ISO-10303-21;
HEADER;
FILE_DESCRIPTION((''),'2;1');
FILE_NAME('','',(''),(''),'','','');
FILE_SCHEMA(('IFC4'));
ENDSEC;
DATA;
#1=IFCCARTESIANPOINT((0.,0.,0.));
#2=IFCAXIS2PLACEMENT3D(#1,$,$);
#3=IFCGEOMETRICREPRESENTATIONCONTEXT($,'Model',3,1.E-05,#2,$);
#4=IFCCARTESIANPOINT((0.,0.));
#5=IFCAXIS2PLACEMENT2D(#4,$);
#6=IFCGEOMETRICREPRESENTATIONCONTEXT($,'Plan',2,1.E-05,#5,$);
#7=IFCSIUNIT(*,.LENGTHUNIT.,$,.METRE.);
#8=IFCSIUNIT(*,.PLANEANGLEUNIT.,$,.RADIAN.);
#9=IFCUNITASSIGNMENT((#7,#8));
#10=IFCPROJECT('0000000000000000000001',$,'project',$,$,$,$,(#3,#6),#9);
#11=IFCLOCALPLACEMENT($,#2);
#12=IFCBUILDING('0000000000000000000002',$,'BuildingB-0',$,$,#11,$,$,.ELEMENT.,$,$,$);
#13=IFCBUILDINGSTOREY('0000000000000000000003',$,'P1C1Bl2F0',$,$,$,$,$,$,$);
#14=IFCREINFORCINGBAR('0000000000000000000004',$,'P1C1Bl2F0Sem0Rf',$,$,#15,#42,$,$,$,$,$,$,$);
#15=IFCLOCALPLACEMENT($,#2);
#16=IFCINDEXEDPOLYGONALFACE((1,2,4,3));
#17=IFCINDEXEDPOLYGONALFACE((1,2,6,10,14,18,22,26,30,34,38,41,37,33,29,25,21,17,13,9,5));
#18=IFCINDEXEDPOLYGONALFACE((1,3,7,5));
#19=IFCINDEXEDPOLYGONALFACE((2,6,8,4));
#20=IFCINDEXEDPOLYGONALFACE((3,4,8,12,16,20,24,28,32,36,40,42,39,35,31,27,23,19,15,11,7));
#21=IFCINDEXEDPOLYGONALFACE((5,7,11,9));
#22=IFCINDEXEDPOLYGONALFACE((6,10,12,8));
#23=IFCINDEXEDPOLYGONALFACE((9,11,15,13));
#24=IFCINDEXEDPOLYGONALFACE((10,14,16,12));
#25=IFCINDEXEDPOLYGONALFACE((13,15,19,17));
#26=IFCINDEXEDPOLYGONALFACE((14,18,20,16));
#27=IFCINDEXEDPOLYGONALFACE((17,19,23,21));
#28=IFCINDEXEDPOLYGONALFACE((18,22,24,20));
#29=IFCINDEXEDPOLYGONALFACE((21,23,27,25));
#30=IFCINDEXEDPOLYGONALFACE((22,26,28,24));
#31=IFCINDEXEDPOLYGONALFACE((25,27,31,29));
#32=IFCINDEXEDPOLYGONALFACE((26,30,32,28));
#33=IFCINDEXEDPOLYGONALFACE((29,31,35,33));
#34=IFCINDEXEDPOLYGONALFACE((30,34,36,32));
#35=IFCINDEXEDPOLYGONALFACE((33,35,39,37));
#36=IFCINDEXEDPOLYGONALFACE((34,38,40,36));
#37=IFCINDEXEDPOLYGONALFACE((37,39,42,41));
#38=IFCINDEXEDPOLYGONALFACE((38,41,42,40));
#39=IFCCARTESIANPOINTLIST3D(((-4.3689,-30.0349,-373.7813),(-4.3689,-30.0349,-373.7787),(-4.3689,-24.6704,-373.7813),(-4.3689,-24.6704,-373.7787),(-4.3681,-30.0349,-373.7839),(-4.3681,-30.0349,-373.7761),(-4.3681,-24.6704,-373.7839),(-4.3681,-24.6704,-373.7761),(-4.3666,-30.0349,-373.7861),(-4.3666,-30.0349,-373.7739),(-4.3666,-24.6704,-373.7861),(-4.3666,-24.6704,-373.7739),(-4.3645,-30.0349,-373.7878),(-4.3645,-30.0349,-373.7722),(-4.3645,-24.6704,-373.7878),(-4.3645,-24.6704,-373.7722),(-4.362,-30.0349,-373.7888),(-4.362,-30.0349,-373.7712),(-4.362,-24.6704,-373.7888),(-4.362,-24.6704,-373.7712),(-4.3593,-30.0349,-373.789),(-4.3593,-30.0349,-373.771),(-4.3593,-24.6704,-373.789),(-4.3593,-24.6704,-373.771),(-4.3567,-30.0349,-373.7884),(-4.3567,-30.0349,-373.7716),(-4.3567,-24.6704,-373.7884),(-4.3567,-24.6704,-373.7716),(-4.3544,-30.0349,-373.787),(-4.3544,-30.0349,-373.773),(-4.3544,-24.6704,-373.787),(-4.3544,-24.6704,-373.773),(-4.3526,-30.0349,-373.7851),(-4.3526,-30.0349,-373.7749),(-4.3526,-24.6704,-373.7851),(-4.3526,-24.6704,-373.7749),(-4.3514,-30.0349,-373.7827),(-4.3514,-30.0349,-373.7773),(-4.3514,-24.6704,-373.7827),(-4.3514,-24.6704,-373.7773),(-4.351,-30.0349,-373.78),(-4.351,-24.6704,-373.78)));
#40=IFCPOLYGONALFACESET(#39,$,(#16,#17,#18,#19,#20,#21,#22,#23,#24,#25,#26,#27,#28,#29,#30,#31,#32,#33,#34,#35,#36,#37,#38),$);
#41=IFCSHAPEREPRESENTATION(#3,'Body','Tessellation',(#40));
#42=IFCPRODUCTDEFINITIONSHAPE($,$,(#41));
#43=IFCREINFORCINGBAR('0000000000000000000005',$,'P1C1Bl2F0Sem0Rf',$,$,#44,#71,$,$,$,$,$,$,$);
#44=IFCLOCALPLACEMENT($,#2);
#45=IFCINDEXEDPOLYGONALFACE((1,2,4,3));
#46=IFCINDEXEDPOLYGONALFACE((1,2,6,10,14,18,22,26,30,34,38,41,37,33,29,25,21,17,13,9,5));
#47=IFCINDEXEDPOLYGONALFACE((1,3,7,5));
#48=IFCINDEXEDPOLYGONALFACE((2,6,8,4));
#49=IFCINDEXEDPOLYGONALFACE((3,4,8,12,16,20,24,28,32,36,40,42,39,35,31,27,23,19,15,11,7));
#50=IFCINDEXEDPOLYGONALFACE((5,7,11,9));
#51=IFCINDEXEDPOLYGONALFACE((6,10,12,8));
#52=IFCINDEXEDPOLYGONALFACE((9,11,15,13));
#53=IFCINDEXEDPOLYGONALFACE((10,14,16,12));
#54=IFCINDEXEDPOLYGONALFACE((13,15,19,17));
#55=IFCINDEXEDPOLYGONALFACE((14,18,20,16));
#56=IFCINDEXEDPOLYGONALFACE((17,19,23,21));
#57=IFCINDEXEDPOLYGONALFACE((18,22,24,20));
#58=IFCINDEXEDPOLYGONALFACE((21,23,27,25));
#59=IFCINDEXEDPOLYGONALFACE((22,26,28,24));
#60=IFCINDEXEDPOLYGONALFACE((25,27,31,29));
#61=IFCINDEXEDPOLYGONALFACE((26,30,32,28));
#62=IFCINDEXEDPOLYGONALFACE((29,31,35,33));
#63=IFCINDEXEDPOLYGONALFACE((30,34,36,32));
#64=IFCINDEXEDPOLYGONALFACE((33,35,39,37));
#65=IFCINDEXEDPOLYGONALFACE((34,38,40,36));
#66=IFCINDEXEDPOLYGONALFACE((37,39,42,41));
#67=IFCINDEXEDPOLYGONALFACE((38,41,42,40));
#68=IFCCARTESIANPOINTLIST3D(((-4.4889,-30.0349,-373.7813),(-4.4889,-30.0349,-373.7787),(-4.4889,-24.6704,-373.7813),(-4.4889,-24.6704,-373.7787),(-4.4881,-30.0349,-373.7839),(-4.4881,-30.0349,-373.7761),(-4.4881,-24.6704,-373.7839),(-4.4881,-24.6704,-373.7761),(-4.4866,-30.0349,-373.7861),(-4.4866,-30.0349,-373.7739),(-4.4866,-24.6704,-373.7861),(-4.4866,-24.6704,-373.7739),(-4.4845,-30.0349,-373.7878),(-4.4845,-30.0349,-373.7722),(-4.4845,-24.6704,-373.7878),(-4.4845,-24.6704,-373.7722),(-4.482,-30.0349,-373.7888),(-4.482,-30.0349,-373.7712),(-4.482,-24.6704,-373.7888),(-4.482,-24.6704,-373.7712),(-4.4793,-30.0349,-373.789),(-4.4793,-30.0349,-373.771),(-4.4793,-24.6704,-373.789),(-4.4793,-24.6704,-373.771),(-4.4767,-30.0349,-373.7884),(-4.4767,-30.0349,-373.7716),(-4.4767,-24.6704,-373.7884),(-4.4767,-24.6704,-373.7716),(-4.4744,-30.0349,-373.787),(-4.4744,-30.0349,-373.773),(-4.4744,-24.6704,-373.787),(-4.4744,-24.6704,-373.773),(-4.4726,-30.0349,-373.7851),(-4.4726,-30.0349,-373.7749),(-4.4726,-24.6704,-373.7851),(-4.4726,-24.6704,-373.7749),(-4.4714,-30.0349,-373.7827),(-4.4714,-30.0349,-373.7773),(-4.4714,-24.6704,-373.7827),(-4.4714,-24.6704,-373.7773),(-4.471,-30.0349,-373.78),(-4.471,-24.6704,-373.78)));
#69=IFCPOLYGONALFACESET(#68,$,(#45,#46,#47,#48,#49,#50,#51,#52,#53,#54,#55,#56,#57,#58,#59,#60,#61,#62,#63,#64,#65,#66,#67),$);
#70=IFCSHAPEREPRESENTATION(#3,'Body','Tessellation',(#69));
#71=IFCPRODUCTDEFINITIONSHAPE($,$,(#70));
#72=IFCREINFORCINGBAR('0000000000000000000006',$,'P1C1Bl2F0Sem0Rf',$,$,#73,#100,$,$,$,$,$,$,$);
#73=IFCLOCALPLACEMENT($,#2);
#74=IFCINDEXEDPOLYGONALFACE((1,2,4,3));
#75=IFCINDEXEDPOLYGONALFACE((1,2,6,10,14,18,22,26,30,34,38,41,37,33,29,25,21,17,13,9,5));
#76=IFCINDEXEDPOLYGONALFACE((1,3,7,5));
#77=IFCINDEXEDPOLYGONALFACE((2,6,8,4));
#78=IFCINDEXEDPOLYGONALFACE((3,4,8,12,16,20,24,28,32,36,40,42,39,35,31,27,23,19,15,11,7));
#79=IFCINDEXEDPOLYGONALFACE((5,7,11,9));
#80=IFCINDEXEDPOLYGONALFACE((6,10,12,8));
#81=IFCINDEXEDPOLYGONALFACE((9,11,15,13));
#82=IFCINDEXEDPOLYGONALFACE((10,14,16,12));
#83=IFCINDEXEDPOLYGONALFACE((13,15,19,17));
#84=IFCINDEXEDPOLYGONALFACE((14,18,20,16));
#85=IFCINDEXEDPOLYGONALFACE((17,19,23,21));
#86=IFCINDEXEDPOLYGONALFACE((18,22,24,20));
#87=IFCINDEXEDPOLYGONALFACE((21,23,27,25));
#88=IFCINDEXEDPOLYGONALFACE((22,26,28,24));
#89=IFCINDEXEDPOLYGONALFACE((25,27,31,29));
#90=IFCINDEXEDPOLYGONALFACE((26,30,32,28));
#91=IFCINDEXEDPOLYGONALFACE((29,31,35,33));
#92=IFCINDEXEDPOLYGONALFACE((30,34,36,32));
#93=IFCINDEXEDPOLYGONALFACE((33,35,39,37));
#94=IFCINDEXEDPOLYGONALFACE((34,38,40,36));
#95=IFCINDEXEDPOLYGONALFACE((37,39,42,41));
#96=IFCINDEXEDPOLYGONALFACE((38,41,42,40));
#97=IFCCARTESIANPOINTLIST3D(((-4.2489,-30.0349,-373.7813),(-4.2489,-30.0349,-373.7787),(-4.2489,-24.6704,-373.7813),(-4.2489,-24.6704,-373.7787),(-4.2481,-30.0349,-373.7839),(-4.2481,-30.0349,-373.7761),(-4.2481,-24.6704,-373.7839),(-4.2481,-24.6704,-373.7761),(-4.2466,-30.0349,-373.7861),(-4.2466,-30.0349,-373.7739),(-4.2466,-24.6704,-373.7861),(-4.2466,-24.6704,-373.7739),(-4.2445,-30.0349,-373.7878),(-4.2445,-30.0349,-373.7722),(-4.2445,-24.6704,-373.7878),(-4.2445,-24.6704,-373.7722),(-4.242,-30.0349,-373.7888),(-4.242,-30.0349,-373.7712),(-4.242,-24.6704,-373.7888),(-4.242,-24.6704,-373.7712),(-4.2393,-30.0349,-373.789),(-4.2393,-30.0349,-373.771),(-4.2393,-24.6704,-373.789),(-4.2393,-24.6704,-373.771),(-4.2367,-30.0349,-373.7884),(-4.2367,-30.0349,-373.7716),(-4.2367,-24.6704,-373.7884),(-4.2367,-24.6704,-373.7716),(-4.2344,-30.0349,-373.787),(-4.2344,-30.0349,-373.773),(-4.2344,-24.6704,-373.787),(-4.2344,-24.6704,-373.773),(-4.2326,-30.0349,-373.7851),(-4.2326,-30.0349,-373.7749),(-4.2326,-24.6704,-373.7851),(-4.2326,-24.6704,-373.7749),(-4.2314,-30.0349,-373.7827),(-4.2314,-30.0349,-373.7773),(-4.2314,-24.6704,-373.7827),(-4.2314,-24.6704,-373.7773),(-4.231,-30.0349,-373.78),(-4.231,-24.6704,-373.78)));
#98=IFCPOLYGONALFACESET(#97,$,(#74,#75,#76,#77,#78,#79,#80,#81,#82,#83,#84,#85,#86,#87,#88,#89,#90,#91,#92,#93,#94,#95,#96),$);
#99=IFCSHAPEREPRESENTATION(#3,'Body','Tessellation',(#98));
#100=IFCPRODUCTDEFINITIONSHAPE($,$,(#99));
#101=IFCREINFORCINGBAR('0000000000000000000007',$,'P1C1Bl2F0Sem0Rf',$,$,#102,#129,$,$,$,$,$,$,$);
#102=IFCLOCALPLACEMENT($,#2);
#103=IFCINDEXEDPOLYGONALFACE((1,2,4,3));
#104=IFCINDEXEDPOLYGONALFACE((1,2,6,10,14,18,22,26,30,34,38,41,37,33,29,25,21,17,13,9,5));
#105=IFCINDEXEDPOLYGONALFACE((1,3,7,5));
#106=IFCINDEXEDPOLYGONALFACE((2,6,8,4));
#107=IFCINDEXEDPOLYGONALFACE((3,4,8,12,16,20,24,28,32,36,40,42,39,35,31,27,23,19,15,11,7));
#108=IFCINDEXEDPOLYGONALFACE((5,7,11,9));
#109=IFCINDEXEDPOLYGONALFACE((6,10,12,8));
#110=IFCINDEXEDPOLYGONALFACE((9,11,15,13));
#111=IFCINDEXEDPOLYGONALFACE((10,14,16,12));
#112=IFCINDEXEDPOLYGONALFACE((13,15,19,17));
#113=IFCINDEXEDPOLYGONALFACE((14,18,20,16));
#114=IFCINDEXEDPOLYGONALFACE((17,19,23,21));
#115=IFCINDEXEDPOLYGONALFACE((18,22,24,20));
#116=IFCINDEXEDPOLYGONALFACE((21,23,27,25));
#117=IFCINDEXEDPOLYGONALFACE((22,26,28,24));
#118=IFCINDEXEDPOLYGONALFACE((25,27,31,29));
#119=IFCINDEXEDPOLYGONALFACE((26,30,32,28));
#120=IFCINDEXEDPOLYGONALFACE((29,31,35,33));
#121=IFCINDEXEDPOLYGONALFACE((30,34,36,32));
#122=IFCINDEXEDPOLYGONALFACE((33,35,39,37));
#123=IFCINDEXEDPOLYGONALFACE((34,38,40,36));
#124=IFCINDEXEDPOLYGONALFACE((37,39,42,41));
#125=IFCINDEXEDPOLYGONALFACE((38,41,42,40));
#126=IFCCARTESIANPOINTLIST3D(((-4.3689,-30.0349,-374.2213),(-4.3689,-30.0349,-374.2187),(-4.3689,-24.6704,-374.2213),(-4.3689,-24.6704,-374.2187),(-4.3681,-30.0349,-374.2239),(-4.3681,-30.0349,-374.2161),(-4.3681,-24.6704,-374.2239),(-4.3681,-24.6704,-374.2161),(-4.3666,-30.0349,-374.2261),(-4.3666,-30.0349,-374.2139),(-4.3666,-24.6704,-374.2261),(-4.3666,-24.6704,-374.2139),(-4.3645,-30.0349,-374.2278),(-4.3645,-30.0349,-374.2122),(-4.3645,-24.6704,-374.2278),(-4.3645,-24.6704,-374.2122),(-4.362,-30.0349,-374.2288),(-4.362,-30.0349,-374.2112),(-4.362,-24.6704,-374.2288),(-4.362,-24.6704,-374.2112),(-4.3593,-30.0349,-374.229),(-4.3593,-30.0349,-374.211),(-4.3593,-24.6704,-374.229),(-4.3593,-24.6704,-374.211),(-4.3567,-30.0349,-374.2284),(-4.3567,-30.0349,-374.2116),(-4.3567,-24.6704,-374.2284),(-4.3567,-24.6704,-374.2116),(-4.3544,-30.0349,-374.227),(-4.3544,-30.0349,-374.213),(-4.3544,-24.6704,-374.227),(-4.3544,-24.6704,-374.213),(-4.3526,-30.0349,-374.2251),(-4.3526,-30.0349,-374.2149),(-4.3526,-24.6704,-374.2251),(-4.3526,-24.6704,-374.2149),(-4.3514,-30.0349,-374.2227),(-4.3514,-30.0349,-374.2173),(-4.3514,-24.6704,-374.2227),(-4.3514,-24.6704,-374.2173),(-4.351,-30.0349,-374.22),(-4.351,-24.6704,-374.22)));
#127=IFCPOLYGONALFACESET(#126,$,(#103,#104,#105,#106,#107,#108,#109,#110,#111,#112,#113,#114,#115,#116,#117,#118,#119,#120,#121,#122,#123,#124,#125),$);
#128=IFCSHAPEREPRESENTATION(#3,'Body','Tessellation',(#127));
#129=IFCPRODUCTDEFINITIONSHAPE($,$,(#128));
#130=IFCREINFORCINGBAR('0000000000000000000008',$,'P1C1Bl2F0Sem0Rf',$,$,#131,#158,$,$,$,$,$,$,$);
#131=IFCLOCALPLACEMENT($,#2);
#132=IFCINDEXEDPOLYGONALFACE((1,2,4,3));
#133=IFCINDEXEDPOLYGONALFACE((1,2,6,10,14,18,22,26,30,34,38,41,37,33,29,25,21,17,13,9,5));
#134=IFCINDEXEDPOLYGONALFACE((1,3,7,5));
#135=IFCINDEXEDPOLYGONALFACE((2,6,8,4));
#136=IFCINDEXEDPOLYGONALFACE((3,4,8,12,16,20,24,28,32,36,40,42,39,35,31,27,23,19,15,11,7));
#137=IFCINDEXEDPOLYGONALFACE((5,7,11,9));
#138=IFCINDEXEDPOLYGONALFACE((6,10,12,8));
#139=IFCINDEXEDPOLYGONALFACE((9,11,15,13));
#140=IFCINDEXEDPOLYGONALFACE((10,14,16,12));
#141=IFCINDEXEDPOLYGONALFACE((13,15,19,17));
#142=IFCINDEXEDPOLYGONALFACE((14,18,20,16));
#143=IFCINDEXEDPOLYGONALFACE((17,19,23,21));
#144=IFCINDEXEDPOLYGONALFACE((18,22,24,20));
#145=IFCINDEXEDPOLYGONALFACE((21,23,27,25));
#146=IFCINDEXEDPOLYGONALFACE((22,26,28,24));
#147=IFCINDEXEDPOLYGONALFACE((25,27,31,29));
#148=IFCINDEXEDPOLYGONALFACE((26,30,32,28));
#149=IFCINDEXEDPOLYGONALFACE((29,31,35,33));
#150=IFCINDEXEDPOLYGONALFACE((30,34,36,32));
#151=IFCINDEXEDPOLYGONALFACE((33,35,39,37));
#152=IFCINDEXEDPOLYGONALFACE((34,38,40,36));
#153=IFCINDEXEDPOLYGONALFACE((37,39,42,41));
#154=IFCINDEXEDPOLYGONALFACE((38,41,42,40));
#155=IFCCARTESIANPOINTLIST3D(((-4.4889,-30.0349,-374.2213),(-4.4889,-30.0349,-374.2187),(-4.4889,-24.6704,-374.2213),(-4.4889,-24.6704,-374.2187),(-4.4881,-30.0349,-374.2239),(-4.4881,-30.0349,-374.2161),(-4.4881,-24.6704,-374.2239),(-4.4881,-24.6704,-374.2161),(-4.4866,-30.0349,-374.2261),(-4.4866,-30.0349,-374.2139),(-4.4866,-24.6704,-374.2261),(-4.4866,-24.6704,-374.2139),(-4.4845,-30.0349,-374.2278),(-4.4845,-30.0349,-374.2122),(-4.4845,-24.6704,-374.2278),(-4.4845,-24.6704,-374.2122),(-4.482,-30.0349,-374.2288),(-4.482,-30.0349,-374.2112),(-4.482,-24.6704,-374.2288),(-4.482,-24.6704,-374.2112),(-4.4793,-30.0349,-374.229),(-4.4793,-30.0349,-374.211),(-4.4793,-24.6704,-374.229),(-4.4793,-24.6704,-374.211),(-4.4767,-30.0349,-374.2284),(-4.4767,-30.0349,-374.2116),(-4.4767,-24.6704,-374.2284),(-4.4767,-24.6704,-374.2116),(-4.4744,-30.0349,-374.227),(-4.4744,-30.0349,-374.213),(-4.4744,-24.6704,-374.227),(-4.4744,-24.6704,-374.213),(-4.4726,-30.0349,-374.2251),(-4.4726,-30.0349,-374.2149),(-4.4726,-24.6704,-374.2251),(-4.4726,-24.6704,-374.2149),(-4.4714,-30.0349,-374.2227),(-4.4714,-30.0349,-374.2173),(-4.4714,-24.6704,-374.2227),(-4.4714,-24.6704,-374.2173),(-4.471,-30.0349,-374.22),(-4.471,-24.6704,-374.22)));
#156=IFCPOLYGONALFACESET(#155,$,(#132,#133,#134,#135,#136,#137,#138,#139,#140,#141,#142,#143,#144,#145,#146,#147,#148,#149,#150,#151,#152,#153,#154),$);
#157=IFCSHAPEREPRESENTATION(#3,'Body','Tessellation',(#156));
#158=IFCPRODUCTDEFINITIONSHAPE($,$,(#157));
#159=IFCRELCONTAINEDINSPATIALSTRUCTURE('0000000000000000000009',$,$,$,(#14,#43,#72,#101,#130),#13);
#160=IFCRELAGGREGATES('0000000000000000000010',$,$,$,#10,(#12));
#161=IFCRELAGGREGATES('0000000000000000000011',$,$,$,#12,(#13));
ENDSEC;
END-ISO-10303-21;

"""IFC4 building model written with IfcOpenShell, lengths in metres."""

from ifc_helpers import new_model, entity, si_unit, origin, origin_2d, place, context, project, spatial, element, save


model = new_model("IFC4")

# Units and contexts
model_context = context("Model", 3, precision=1e-05, world=origin())
plan_context = context("Plan", 2, precision=1e-05, world=origin_2d())
ifc_project = project(units=[si_unit("LENGTHUNIT", "METRE"), si_unit("PLANEANGLEUNIT", "RADIAN")], contexts=[model_context, plan_context])

# Building, storey
building_placement = place(None, origin())
building = spatial("IfcBuilding", under=ifc_project, at=building_placement, Name="BuildingB-0", CompositionType="ELEMENT")
storey = spatial("IfcBuildingStorey", under=building, Name="P1C1Bl2F0")

# Reinforcing bars
element("IfcReinforcingBar", 1, inside=storey, Name="P1C1Bl2F0Sem0Rf", context=model_context, shape_type="SweptSolid", body=[
    entity("IfcSurfaceCurveSweptAreaSolid", entity("IfcCircleProfileDef", "AREA", None, None, 0.009), None, entity("IfcPolyline", [entity("IfcCartesianPoint", [4.36, 24.6704, 373.78]), entity("IfcCartesianPoint", [4.36, 30.0349, 373.78])]), None, None, entity("IfcPlane", entity("IfcAxis2Placement3D", entity("IfcCartesianPoint", [4.36, 24.6704, 373.78]), entity("IfcDirection", [0.0, 0.0, 1.0]), entity("IfcDirection", [1.0, 0.0, 0.0])))),
])
element("IfcReinforcingBar", 2, inside=storey, Name="P1C1Bl2F0Sem0Rf", context=model_context, shape_type="SweptSolid", body=[
    entity("IfcSurfaceCurveSweptAreaSolid", entity("IfcCircleProfileDef", "AREA", None, None, 0.009), None, entity("IfcPolyline", [entity("IfcCartesianPoint", [4.48, 24.6704, 373.78]), entity("IfcCartesianPoint", [4.48, 30.0349, 373.78])]), None, None, entity("IfcPlane", entity("IfcAxis2Placement3D", entity("IfcCartesianPoint", [4.48, 24.6704, 373.78]), entity("IfcDirection", [0.0, 0.0, 1.0]), entity("IfcDirection", [1.0, 0.0, 0.0])))),
])
element("IfcReinforcingBar", 3, inside=storey, Name="P1C1Bl2F0Sem0Rf", context=model_context, shape_type="SweptSolid", body=[
    entity("IfcSurfaceCurveSweptAreaSolid", entity("IfcCircleProfileDef", "AREA", None, None, 0.009), None, entity("IfcPolyline", [entity("IfcCartesianPoint", [4.24, 24.6704, 373.78]), entity("IfcCartesianPoint", [4.24, 30.0349, 373.78])]), None, None, entity("IfcPlane", entity("IfcAxis2Placement3D", entity("IfcCartesianPoint", [4.24, 24.6704, 373.78]), entity("IfcDirection", [0.0, 0.0, 1.0]), entity("IfcDirection", [1.0, 0.0, 0.0])))),
])
element("IfcReinforcingBar", 4, inside=storey, Name="P1C1Bl2F0Sem0Rf", context=model_context, shape_type="SweptSolid", body=[
    entity("IfcSurfaceCurveSweptAreaSolid", entity("IfcCircleProfileDef", "AREA", None, None, 0.009), None, entity("IfcPolyline", [entity("IfcCartesianPoint", [4.36, 24.6704, 374.22]), entity("IfcCartesianPoint", [4.36, 30.0349, 374.22])]), None, None, entity("IfcPlane", entity("IfcAxis2Placement3D", entity("IfcCartesianPoint", [4.36, 24.6704, 374.22]), entity("IfcDirection", [0.0, 0.0, 1.0]), entity("IfcDirection", [1.0, 0.0, 0.0])))),
])
element("IfcReinforcingBar", 5, inside=storey, Name="P1C1Bl2F0Sem0Rf", context=model_context, shape_type="SweptSolid", body=[
    entity("IfcSurfaceCurveSweptAreaSolid", entity("IfcCircleProfileDef", "AREA", None, None, 0.009), None, entity("IfcPolyline", [entity("IfcCartesianPoint", [4.48, 24.6704, 374.22]), entity("IfcCartesianPoint", [4.48, 30.0349, 374.22])]), None, None, entity("IfcPlane", entity("IfcAxis2Placement3D", entity("IfcCartesianPoint", [4.48, 24.6704, 374.22]), entity("IfcDirection", [0.0, 0.0, 1.0]), entity("IfcDirection", [1.0, 0.0, 0.0])))),
])

save(model, "model.ifc")
